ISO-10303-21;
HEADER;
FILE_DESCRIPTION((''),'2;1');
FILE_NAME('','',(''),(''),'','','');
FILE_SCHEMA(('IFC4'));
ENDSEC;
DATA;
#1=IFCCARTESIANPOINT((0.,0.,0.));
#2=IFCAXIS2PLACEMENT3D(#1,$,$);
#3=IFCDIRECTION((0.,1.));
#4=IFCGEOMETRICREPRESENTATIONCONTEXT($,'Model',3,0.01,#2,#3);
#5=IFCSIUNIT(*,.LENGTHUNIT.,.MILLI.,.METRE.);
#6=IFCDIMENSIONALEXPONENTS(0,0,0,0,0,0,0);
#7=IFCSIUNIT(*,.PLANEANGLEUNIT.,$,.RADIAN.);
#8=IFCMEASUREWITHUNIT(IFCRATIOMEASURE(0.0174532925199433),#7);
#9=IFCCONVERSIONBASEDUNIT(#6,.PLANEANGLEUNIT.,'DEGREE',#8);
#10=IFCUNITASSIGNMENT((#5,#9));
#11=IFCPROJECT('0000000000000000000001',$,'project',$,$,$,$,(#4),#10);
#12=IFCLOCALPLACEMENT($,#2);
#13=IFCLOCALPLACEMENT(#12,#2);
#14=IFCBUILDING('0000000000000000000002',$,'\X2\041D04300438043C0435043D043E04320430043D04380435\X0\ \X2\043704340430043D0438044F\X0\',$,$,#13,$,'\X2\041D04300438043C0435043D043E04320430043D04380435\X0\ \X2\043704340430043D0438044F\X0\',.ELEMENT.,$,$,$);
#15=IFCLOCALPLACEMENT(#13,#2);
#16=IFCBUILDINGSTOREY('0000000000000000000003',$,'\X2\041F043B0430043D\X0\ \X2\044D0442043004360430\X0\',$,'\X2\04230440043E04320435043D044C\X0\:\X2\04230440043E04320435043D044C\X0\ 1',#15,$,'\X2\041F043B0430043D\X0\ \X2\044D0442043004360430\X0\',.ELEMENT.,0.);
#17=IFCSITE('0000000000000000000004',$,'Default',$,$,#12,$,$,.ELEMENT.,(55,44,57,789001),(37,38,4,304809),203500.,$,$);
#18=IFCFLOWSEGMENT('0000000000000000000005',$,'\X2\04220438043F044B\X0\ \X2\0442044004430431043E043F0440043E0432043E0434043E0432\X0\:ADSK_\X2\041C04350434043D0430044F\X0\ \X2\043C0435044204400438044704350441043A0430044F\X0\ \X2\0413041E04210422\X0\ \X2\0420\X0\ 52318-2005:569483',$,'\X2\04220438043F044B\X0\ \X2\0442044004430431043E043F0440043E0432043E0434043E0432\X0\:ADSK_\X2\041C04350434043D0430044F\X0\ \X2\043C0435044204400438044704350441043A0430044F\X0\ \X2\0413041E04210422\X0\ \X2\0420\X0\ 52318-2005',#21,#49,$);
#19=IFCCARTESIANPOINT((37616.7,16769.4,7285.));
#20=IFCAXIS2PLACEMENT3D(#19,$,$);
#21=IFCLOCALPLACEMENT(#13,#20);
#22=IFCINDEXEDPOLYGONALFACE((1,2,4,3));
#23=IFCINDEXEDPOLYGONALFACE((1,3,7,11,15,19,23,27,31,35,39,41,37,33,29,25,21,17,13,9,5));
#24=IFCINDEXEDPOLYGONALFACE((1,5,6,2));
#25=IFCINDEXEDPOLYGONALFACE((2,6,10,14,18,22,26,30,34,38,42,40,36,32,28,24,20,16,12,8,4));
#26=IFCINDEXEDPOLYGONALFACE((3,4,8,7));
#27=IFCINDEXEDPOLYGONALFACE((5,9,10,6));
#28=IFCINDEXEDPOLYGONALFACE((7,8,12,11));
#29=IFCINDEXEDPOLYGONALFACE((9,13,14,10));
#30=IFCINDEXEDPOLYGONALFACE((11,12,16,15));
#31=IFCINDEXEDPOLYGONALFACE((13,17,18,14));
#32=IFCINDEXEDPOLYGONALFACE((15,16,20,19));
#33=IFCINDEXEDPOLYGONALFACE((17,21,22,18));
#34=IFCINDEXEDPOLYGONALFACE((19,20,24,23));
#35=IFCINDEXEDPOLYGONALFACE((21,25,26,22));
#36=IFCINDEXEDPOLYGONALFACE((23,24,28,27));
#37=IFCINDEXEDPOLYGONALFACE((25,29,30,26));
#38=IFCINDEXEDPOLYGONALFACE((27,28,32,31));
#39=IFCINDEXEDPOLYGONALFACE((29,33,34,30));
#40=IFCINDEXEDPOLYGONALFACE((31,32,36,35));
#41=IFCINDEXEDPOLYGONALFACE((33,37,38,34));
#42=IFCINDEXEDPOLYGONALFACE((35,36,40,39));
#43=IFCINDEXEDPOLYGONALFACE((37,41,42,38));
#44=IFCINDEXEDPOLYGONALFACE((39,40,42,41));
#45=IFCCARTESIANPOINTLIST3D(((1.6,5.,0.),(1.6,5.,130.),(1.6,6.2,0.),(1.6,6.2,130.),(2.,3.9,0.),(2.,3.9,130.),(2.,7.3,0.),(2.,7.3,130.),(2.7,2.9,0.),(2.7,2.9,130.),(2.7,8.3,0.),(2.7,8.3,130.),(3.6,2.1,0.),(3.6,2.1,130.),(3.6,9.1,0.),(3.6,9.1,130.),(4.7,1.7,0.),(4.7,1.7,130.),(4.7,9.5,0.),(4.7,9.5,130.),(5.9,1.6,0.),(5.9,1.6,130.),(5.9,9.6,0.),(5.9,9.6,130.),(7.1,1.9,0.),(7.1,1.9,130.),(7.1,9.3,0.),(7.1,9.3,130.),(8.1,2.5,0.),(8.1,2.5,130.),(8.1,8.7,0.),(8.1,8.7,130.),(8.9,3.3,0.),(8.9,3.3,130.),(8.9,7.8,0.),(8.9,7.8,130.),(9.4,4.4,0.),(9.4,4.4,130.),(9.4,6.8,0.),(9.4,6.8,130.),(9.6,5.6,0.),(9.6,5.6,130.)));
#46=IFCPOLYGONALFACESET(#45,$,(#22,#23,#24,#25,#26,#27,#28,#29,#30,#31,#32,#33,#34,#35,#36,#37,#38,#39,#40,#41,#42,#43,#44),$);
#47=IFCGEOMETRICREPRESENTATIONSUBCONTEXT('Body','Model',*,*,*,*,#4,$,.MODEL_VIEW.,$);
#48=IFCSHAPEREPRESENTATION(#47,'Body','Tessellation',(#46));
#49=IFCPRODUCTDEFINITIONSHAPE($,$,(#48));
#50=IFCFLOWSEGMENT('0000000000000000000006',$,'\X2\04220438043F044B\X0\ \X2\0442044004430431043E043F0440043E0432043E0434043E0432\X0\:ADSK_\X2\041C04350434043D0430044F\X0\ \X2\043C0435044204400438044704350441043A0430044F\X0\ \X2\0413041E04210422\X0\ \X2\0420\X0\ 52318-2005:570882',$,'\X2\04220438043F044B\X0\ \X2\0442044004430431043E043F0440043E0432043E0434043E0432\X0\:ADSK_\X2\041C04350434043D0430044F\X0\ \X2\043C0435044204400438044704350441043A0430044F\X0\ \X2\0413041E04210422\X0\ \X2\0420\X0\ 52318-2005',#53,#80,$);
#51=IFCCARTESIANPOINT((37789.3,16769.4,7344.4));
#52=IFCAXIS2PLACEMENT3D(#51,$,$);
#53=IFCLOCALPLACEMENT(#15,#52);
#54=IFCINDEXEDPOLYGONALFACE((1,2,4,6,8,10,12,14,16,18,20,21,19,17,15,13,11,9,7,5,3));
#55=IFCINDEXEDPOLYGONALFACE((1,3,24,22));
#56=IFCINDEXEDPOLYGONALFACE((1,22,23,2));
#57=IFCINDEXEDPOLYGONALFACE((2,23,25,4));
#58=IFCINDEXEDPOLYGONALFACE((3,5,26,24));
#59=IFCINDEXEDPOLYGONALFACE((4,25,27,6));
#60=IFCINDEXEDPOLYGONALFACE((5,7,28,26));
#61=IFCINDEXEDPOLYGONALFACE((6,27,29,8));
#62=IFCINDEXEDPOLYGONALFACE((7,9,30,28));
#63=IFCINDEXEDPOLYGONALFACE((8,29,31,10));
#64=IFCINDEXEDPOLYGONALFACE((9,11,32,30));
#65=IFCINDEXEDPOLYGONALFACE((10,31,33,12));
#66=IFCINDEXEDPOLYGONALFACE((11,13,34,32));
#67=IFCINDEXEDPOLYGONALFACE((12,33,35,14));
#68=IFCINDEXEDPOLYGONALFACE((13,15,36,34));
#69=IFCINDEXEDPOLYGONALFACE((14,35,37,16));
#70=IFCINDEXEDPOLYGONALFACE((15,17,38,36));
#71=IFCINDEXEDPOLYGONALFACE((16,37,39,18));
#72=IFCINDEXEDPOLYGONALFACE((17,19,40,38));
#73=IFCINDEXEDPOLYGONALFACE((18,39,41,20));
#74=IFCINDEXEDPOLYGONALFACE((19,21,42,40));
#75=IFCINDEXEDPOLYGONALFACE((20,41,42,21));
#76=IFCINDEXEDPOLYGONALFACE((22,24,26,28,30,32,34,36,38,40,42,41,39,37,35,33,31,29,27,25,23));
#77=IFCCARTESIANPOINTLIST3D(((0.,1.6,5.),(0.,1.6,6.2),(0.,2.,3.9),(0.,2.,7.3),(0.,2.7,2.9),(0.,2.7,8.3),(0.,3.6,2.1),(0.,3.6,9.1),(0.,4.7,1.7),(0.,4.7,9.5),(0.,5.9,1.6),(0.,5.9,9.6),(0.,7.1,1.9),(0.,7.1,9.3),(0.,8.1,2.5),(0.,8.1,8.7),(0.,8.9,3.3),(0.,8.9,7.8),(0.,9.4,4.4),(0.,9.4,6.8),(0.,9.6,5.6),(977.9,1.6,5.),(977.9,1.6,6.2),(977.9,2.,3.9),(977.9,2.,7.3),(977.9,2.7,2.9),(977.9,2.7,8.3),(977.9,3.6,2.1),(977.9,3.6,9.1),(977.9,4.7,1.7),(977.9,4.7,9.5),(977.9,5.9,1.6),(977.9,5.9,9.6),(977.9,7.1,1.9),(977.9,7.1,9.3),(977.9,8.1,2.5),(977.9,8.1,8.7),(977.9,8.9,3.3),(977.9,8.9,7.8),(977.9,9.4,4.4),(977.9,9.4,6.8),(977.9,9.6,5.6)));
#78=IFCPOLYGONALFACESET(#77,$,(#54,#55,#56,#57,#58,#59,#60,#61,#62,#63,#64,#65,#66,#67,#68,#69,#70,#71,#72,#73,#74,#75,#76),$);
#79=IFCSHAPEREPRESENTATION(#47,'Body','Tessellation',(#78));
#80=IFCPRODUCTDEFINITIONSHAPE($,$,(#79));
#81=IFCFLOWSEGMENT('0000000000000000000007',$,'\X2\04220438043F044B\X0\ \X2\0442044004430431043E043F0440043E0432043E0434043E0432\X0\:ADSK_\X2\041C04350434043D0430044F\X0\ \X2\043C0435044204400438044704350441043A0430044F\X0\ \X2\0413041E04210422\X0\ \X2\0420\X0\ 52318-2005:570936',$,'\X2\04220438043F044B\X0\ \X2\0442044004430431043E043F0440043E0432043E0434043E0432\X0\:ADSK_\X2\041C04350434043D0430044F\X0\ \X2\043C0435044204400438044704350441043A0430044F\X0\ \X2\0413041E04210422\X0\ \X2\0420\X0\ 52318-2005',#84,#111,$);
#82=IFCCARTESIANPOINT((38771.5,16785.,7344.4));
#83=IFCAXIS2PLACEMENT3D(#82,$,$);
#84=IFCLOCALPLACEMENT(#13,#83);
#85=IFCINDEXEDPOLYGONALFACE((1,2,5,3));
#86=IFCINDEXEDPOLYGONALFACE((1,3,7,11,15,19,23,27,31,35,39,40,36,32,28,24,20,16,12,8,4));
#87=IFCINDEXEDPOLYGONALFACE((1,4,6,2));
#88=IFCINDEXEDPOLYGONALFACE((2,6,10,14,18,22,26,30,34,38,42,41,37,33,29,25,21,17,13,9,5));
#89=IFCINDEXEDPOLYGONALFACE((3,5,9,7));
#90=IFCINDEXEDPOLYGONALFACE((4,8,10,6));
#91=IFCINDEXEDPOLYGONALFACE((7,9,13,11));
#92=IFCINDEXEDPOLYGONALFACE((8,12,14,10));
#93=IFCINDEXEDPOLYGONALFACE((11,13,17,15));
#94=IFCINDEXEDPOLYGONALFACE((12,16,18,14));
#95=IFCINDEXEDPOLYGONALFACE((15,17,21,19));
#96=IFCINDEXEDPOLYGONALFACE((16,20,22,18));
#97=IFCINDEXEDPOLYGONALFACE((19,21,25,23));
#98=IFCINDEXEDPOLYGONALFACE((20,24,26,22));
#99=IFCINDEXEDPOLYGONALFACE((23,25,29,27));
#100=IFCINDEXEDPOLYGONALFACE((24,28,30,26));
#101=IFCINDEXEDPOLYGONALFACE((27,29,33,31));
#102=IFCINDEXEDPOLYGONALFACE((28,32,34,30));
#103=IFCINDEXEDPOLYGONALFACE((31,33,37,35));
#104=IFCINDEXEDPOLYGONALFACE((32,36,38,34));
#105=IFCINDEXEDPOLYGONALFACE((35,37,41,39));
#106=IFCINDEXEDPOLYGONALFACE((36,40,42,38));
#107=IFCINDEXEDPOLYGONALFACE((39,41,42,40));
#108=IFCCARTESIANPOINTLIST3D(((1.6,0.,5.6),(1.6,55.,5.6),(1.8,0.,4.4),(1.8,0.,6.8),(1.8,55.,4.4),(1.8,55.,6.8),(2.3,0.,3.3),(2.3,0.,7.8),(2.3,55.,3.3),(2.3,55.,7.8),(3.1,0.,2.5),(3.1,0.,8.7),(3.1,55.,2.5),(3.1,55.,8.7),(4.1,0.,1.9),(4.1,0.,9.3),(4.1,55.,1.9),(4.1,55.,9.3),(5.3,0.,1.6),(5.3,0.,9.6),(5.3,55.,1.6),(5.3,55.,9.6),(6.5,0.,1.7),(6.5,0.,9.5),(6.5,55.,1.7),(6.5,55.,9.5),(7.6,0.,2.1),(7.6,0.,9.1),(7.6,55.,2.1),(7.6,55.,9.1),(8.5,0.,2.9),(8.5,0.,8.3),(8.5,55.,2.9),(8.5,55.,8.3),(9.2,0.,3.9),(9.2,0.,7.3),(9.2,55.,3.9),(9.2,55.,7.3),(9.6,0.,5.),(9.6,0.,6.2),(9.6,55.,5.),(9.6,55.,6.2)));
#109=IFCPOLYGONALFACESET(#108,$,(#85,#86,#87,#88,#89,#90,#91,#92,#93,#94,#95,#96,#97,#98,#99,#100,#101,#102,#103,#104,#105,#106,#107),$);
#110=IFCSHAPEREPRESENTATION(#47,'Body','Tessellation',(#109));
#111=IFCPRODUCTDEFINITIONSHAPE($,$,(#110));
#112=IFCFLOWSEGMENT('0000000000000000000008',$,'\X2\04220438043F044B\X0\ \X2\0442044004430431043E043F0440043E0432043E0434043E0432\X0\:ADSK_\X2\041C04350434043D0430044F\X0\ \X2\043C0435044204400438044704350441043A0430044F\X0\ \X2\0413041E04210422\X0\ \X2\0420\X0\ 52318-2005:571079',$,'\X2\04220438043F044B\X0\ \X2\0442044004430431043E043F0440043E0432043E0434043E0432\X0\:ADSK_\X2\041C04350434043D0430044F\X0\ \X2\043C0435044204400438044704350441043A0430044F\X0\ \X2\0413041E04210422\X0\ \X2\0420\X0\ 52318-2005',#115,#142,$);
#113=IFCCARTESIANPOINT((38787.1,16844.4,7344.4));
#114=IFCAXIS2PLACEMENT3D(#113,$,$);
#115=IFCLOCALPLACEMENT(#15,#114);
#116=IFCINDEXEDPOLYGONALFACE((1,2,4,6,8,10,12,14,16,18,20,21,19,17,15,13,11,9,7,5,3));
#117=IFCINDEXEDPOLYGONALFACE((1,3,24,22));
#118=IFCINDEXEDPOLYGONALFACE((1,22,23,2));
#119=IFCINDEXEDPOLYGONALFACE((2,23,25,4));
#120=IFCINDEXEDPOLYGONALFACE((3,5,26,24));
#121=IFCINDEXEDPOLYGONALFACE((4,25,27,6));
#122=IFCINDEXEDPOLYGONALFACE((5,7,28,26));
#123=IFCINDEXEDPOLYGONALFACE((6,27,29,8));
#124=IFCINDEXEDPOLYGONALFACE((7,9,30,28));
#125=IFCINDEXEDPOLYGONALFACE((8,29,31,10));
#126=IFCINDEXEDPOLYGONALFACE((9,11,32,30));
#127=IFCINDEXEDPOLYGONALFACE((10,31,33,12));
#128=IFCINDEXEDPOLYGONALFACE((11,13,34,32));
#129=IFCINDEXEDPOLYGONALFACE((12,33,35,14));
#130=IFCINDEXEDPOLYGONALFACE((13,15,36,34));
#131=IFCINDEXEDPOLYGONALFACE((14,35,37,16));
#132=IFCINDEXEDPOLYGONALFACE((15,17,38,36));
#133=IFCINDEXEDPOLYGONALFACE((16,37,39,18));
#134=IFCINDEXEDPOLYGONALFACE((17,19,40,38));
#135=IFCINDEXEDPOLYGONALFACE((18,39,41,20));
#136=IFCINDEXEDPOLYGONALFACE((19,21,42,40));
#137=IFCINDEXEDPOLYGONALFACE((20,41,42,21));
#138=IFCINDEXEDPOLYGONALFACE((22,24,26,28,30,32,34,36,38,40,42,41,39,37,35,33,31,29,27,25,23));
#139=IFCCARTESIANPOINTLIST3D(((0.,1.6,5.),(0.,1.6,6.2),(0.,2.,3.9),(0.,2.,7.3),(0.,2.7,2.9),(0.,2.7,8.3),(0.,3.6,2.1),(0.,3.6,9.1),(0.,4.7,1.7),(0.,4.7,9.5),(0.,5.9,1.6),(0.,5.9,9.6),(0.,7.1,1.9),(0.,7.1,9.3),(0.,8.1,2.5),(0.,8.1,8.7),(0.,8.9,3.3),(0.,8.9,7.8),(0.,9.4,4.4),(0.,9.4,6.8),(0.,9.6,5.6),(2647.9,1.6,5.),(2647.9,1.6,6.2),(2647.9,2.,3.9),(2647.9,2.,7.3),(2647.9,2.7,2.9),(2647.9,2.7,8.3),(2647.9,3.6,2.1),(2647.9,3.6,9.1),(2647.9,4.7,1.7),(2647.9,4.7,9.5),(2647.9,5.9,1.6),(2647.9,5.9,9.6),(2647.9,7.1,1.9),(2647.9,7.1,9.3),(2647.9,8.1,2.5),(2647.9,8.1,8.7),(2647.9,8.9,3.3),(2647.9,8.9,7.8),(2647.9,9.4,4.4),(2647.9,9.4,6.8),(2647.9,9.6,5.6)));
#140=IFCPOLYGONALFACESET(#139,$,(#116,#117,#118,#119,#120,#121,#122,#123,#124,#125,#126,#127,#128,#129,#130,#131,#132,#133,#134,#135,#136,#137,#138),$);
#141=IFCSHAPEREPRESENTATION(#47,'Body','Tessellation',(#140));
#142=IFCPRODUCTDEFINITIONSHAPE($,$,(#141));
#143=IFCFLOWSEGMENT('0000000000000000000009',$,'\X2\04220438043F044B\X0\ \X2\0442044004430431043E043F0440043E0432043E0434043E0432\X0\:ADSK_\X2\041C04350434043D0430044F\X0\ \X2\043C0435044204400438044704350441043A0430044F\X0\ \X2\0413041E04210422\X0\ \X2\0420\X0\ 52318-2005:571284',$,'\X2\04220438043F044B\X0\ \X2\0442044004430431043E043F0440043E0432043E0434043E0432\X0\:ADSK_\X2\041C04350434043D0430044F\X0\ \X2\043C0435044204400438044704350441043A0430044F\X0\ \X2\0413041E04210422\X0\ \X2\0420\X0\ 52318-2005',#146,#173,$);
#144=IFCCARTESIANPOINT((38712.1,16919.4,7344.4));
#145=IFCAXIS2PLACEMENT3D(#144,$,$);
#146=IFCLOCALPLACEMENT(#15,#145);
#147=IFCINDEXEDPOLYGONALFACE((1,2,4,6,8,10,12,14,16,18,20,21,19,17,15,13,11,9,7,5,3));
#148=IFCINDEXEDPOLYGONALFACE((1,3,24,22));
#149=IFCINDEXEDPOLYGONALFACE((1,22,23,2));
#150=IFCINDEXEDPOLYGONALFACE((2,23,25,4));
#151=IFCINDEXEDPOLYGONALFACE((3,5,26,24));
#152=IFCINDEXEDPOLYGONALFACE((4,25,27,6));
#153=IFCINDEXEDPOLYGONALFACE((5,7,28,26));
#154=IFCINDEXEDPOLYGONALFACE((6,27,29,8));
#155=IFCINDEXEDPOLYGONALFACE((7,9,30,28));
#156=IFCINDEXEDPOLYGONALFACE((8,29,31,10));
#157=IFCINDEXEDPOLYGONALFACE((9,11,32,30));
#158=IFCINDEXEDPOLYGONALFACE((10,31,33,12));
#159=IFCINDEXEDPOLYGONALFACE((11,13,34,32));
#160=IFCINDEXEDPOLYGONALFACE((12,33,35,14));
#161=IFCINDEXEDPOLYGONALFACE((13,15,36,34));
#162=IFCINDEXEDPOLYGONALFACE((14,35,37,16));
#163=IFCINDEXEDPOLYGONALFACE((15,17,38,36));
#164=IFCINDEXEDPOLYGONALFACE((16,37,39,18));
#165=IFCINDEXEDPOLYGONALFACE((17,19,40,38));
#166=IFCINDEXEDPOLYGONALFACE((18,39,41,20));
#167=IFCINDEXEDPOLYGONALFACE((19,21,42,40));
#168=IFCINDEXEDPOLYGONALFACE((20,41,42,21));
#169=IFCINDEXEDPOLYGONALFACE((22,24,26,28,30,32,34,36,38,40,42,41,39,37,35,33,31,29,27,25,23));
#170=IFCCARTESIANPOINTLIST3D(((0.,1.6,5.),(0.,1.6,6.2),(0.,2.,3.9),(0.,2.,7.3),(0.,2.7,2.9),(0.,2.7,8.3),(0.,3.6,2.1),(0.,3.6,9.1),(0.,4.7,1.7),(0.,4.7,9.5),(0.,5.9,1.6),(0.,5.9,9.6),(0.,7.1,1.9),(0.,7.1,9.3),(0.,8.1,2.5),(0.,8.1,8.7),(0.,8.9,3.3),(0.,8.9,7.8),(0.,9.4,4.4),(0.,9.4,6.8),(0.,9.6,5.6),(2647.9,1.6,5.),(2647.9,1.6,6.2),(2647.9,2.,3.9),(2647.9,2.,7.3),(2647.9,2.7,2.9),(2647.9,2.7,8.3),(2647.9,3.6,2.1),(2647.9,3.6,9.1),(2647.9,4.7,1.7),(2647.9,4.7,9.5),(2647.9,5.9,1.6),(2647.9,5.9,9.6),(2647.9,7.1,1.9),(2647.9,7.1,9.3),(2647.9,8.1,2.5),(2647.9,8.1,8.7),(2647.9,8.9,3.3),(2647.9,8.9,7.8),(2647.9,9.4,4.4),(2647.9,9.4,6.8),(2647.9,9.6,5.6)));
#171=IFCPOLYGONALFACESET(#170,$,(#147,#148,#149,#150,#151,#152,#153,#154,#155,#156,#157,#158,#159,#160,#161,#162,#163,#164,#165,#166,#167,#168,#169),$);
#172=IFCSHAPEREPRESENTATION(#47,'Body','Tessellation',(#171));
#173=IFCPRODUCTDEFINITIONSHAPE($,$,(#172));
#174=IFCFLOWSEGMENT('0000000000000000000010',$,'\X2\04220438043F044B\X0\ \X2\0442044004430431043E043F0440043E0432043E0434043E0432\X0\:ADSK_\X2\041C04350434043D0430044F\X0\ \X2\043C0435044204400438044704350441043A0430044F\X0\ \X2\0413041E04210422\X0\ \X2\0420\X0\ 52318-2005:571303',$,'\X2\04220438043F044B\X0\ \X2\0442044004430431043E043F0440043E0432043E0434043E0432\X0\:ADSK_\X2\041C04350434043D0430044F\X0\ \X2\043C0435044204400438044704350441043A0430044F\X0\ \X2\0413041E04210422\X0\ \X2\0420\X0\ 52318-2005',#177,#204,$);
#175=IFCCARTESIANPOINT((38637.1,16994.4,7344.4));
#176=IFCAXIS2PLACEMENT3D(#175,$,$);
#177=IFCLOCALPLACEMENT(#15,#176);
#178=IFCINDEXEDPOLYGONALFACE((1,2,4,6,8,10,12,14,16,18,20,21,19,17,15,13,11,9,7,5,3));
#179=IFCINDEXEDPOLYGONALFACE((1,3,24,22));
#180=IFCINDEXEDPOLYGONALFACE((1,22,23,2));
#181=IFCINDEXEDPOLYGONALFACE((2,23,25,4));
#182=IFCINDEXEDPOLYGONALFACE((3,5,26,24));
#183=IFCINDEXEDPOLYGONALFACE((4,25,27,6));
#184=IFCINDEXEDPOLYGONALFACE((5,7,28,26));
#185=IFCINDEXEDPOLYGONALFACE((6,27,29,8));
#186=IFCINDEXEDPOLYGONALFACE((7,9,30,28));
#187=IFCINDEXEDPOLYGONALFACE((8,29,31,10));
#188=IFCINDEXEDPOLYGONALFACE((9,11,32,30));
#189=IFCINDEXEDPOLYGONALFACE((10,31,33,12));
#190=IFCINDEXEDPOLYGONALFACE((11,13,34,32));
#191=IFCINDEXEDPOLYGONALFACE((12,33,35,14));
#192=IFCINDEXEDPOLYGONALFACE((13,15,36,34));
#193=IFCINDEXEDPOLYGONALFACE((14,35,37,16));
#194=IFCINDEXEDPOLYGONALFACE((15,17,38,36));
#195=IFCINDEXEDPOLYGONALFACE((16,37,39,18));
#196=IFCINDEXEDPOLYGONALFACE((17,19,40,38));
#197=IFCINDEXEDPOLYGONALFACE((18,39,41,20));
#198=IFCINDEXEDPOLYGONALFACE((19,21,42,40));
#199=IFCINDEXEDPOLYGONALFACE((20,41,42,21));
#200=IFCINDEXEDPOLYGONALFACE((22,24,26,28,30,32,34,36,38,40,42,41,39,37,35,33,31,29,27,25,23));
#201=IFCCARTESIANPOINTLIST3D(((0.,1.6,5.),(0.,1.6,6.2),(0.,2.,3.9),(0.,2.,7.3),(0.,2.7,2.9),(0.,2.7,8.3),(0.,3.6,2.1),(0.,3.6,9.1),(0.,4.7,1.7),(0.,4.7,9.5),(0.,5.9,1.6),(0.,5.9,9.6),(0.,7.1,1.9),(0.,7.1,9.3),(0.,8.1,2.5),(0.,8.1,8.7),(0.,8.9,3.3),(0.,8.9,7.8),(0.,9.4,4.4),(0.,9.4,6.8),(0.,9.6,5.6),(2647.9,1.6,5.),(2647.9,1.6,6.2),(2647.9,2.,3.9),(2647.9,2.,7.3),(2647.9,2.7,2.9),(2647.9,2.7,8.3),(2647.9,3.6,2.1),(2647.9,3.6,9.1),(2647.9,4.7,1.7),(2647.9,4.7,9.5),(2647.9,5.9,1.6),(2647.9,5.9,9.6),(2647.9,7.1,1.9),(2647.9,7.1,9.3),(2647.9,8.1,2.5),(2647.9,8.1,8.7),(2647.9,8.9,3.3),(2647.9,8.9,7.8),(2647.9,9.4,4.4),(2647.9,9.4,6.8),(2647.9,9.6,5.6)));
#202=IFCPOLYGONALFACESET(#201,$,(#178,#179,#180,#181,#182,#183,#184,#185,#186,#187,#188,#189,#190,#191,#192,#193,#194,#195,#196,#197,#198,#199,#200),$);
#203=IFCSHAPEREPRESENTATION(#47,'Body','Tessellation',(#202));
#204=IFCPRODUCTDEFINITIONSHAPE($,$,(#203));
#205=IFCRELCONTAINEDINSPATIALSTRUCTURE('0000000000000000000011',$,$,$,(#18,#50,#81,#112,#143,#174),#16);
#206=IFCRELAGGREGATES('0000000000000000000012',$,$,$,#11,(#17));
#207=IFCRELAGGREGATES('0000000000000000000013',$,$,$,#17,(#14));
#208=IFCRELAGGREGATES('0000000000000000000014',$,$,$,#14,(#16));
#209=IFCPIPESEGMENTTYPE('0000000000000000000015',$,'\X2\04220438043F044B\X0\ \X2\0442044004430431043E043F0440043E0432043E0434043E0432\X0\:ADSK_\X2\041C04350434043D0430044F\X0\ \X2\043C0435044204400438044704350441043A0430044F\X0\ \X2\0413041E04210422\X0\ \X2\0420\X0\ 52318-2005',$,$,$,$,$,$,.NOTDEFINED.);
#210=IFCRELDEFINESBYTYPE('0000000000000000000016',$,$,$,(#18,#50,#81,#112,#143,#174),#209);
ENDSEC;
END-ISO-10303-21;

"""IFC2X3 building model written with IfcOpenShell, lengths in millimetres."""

from ifc_helpers import new_model, entity, si_unit, converted_unit, direction, frame, frame_2d, origin, origin_2d_with_axis, place, context, subcontext, project, spatial, circle, extrude, type_object, element, save


model = new_model("IFC2X3")

# Units and contexts
model_context = context("Model", 3, precision=0.01, world=origin(), true_north=direction((0.0, 1.0)))
body_context = subcontext(model_context, "Body", "Model", "MODEL_VIEW")
ifc_project = project(units=[si_unit("LENGTHUNIT", "METRE", prefix="MILLI"), converted_unit("PLANEANGLEUNIT", "DEGREE", entity("IfcRatioMeasure", 0.0174532925199433), si_unit("PLANEANGLEUNIT", "RADIAN"), dimensions=[0, 0, 0, 0, 0, 0, 0])], contexts=[model_context])

# Site, building, storey
site_placement = place(None, frame((0.0, 0.0, 0.0)))
site = spatial("IfcSite", under=ifc_project, at=site_placement, Name="Default", CompositionType="ELEMENT", RefLatitude=(55, 44, 57, 789001), RefLongitude=(37, 38, 4, 304809), RefElevation=203500.0)
building_placement = place(site_placement, origin())
building = spatial("IfcBuilding", under=site, at=building_placement, Name="Наименование здания", LongName="Наименование здания", CompositionType="ELEMENT")
storey_placement = place(building_placement, origin())
storey = spatial("IfcBuildingStorey", under=building, at=storey_placement, Name="План этажа", ObjectType="Уровень:Уровень 1", LongName="План этажа", CompositionType="ELEMENT", Elevation=0.0)

# Flow segments
pipe_segment_type = type_object("IfcPipeSegmentType", Name="Типы трубопроводов:ADSK_Медная метрическая ГОСТ Р 52318-2005", PredefinedType="NOTDEFINED")
flow_segment_1_placement = place(building_placement, frame((37616.7, 16769.4, 7285.0)))
element("IfcFlowSegment", 1, at=flow_segment_1_placement, inside=storey, type_object=pipe_segment_type, Name="Типы трубопроводов:ADSK_Медная метрическая ГОСТ Р 52318-2005:569483", ObjectType="Типы трубопроводов:ADSK_Медная метрическая ГОСТ Р 52318-2005", context=body_context, shape_type="SweptSolid", body=[
    extrude(circle(Radius=4.0, at=origin_2d_with_axis()), frame((5.6, 5.6, 0.0)), (0.0, 0.0, 1.0), 130.0),
])
flow_segment_2_placement = place(storey_placement, frame((37789.3, 16769.4, 7344.4)))
element("IfcFlowSegment", 2, at=flow_segment_2_placement, inside=storey, type_object=pipe_segment_type, Name="Типы трубопроводов:ADSK_Медная метрическая ГОСТ Р 52318-2005:570882", ObjectType="Типы трубопроводов:ADSK_Медная метрическая ГОСТ Р 52318-2005", context=body_context, shape_type="SweptSolid", body=[
    extrude(circle(Radius=4.0, at=frame_2d((0.0, 0.0), x_axis=(1.0, 0.0))), frame((0.0, 5.6, 5.6), z_axis=(1.0, 0.0, 0.0), x_axis=(0.0, 1.0, 0.0)), (0.0, 0.0, 1.0), 977.9),
])
flow_segment_3_placement = place(building_placement, frame((38771.5, 16785.0, 7344.4)))
element("IfcFlowSegment", 3, at=flow_segment_3_placement, inside=storey, type_object=pipe_segment_type, Name="Типы трубопроводов:ADSK_Медная метрическая ГОСТ Р 52318-2005:570936", ObjectType="Типы трубопроводов:ADSK_Медная метрическая ГОСТ Р 52318-2005", context=body_context, shape_type="SweptSolid", body=[
    extrude(circle(Radius=4.0, at=frame_2d((0.0, 0.0), x_axis=(1.0, 0.0))), frame((5.6, 0.0, 5.6), z_axis=(0.0, 1.0, 0.0), x_axis=(-1.0, 0.0, 0.0)), (0.0, 0.0, 1.0), 55.0),
])
flow_segment_4_placement = place(storey_placement, frame((38787.1, 16844.4, 7344.4)))
element("IfcFlowSegment", 4, at=flow_segment_4_placement, inside=storey, type_object=pipe_segment_type, Name="Типы трубопроводов:ADSK_Медная метрическая ГОСТ Р 52318-2005:571079", ObjectType="Типы трубопроводов:ADSK_Медная метрическая ГОСТ Р 52318-2005", context=body_context, shape_type="SweptSolid", body=[
    extrude(circle(Radius=4.0, at=frame_2d((0.0, 0.0), x_axis=(1.0, 0.0))), frame((0.0, 5.6, 5.6), z_axis=(1.0, 0.0, 0.0), x_axis=(0.0, 1.0, 0.0)), (0.0, 0.0, 1.0), 2647.9),
])
flow_segment_5_placement = place(storey_placement, frame((38712.1, 16919.4, 7344.4)))
element("IfcFlowSegment", 5, at=flow_segment_5_placement, inside=storey, type_object=pipe_segment_type, Name="Типы трубопроводов:ADSK_Медная метрическая ГОСТ Р 52318-2005:571284", ObjectType="Типы трубопроводов:ADSK_Медная метрическая ГОСТ Р 52318-2005", context=body_context, shape_type="SweptSolid", body=[
    extrude(circle(Radius=4.0, at=frame_2d((0.0, 0.0), x_axis=(1.0, 0.0))), frame((0.0, 5.6, 5.6), z_axis=(1.0, 0.0, 0.0), x_axis=(0.0, 1.0, 0.0)), (0.0, 0.0, 1.0), 2647.9),
])
flow_segment_6_placement = place(storey_placement, frame((38637.1, 16994.4, 7344.4)))
element("IfcFlowSegment", 6, at=flow_segment_6_placement, inside=storey, type_object=pipe_segment_type, Name="Типы трубопроводов:ADSK_Медная метрическая ГОСТ Р 52318-2005:571303", ObjectType="Типы трубопроводов:ADSK_Медная метрическая ГОСТ Р 52318-2005", context=body_context, shape_type="SweptSolid", body=[
    extrude(circle(Radius=4.0, at=frame_2d((0.0, 0.0), x_axis=(1.0, 0.0))), frame((0.0, 5.6, 5.6), z_axis=(1.0, 0.0, 0.0), x_axis=(0.0, 1.0, 0.0)), (0.0, 0.0, 1.0), 2647.9),
])

save(model, "model.ifc")
